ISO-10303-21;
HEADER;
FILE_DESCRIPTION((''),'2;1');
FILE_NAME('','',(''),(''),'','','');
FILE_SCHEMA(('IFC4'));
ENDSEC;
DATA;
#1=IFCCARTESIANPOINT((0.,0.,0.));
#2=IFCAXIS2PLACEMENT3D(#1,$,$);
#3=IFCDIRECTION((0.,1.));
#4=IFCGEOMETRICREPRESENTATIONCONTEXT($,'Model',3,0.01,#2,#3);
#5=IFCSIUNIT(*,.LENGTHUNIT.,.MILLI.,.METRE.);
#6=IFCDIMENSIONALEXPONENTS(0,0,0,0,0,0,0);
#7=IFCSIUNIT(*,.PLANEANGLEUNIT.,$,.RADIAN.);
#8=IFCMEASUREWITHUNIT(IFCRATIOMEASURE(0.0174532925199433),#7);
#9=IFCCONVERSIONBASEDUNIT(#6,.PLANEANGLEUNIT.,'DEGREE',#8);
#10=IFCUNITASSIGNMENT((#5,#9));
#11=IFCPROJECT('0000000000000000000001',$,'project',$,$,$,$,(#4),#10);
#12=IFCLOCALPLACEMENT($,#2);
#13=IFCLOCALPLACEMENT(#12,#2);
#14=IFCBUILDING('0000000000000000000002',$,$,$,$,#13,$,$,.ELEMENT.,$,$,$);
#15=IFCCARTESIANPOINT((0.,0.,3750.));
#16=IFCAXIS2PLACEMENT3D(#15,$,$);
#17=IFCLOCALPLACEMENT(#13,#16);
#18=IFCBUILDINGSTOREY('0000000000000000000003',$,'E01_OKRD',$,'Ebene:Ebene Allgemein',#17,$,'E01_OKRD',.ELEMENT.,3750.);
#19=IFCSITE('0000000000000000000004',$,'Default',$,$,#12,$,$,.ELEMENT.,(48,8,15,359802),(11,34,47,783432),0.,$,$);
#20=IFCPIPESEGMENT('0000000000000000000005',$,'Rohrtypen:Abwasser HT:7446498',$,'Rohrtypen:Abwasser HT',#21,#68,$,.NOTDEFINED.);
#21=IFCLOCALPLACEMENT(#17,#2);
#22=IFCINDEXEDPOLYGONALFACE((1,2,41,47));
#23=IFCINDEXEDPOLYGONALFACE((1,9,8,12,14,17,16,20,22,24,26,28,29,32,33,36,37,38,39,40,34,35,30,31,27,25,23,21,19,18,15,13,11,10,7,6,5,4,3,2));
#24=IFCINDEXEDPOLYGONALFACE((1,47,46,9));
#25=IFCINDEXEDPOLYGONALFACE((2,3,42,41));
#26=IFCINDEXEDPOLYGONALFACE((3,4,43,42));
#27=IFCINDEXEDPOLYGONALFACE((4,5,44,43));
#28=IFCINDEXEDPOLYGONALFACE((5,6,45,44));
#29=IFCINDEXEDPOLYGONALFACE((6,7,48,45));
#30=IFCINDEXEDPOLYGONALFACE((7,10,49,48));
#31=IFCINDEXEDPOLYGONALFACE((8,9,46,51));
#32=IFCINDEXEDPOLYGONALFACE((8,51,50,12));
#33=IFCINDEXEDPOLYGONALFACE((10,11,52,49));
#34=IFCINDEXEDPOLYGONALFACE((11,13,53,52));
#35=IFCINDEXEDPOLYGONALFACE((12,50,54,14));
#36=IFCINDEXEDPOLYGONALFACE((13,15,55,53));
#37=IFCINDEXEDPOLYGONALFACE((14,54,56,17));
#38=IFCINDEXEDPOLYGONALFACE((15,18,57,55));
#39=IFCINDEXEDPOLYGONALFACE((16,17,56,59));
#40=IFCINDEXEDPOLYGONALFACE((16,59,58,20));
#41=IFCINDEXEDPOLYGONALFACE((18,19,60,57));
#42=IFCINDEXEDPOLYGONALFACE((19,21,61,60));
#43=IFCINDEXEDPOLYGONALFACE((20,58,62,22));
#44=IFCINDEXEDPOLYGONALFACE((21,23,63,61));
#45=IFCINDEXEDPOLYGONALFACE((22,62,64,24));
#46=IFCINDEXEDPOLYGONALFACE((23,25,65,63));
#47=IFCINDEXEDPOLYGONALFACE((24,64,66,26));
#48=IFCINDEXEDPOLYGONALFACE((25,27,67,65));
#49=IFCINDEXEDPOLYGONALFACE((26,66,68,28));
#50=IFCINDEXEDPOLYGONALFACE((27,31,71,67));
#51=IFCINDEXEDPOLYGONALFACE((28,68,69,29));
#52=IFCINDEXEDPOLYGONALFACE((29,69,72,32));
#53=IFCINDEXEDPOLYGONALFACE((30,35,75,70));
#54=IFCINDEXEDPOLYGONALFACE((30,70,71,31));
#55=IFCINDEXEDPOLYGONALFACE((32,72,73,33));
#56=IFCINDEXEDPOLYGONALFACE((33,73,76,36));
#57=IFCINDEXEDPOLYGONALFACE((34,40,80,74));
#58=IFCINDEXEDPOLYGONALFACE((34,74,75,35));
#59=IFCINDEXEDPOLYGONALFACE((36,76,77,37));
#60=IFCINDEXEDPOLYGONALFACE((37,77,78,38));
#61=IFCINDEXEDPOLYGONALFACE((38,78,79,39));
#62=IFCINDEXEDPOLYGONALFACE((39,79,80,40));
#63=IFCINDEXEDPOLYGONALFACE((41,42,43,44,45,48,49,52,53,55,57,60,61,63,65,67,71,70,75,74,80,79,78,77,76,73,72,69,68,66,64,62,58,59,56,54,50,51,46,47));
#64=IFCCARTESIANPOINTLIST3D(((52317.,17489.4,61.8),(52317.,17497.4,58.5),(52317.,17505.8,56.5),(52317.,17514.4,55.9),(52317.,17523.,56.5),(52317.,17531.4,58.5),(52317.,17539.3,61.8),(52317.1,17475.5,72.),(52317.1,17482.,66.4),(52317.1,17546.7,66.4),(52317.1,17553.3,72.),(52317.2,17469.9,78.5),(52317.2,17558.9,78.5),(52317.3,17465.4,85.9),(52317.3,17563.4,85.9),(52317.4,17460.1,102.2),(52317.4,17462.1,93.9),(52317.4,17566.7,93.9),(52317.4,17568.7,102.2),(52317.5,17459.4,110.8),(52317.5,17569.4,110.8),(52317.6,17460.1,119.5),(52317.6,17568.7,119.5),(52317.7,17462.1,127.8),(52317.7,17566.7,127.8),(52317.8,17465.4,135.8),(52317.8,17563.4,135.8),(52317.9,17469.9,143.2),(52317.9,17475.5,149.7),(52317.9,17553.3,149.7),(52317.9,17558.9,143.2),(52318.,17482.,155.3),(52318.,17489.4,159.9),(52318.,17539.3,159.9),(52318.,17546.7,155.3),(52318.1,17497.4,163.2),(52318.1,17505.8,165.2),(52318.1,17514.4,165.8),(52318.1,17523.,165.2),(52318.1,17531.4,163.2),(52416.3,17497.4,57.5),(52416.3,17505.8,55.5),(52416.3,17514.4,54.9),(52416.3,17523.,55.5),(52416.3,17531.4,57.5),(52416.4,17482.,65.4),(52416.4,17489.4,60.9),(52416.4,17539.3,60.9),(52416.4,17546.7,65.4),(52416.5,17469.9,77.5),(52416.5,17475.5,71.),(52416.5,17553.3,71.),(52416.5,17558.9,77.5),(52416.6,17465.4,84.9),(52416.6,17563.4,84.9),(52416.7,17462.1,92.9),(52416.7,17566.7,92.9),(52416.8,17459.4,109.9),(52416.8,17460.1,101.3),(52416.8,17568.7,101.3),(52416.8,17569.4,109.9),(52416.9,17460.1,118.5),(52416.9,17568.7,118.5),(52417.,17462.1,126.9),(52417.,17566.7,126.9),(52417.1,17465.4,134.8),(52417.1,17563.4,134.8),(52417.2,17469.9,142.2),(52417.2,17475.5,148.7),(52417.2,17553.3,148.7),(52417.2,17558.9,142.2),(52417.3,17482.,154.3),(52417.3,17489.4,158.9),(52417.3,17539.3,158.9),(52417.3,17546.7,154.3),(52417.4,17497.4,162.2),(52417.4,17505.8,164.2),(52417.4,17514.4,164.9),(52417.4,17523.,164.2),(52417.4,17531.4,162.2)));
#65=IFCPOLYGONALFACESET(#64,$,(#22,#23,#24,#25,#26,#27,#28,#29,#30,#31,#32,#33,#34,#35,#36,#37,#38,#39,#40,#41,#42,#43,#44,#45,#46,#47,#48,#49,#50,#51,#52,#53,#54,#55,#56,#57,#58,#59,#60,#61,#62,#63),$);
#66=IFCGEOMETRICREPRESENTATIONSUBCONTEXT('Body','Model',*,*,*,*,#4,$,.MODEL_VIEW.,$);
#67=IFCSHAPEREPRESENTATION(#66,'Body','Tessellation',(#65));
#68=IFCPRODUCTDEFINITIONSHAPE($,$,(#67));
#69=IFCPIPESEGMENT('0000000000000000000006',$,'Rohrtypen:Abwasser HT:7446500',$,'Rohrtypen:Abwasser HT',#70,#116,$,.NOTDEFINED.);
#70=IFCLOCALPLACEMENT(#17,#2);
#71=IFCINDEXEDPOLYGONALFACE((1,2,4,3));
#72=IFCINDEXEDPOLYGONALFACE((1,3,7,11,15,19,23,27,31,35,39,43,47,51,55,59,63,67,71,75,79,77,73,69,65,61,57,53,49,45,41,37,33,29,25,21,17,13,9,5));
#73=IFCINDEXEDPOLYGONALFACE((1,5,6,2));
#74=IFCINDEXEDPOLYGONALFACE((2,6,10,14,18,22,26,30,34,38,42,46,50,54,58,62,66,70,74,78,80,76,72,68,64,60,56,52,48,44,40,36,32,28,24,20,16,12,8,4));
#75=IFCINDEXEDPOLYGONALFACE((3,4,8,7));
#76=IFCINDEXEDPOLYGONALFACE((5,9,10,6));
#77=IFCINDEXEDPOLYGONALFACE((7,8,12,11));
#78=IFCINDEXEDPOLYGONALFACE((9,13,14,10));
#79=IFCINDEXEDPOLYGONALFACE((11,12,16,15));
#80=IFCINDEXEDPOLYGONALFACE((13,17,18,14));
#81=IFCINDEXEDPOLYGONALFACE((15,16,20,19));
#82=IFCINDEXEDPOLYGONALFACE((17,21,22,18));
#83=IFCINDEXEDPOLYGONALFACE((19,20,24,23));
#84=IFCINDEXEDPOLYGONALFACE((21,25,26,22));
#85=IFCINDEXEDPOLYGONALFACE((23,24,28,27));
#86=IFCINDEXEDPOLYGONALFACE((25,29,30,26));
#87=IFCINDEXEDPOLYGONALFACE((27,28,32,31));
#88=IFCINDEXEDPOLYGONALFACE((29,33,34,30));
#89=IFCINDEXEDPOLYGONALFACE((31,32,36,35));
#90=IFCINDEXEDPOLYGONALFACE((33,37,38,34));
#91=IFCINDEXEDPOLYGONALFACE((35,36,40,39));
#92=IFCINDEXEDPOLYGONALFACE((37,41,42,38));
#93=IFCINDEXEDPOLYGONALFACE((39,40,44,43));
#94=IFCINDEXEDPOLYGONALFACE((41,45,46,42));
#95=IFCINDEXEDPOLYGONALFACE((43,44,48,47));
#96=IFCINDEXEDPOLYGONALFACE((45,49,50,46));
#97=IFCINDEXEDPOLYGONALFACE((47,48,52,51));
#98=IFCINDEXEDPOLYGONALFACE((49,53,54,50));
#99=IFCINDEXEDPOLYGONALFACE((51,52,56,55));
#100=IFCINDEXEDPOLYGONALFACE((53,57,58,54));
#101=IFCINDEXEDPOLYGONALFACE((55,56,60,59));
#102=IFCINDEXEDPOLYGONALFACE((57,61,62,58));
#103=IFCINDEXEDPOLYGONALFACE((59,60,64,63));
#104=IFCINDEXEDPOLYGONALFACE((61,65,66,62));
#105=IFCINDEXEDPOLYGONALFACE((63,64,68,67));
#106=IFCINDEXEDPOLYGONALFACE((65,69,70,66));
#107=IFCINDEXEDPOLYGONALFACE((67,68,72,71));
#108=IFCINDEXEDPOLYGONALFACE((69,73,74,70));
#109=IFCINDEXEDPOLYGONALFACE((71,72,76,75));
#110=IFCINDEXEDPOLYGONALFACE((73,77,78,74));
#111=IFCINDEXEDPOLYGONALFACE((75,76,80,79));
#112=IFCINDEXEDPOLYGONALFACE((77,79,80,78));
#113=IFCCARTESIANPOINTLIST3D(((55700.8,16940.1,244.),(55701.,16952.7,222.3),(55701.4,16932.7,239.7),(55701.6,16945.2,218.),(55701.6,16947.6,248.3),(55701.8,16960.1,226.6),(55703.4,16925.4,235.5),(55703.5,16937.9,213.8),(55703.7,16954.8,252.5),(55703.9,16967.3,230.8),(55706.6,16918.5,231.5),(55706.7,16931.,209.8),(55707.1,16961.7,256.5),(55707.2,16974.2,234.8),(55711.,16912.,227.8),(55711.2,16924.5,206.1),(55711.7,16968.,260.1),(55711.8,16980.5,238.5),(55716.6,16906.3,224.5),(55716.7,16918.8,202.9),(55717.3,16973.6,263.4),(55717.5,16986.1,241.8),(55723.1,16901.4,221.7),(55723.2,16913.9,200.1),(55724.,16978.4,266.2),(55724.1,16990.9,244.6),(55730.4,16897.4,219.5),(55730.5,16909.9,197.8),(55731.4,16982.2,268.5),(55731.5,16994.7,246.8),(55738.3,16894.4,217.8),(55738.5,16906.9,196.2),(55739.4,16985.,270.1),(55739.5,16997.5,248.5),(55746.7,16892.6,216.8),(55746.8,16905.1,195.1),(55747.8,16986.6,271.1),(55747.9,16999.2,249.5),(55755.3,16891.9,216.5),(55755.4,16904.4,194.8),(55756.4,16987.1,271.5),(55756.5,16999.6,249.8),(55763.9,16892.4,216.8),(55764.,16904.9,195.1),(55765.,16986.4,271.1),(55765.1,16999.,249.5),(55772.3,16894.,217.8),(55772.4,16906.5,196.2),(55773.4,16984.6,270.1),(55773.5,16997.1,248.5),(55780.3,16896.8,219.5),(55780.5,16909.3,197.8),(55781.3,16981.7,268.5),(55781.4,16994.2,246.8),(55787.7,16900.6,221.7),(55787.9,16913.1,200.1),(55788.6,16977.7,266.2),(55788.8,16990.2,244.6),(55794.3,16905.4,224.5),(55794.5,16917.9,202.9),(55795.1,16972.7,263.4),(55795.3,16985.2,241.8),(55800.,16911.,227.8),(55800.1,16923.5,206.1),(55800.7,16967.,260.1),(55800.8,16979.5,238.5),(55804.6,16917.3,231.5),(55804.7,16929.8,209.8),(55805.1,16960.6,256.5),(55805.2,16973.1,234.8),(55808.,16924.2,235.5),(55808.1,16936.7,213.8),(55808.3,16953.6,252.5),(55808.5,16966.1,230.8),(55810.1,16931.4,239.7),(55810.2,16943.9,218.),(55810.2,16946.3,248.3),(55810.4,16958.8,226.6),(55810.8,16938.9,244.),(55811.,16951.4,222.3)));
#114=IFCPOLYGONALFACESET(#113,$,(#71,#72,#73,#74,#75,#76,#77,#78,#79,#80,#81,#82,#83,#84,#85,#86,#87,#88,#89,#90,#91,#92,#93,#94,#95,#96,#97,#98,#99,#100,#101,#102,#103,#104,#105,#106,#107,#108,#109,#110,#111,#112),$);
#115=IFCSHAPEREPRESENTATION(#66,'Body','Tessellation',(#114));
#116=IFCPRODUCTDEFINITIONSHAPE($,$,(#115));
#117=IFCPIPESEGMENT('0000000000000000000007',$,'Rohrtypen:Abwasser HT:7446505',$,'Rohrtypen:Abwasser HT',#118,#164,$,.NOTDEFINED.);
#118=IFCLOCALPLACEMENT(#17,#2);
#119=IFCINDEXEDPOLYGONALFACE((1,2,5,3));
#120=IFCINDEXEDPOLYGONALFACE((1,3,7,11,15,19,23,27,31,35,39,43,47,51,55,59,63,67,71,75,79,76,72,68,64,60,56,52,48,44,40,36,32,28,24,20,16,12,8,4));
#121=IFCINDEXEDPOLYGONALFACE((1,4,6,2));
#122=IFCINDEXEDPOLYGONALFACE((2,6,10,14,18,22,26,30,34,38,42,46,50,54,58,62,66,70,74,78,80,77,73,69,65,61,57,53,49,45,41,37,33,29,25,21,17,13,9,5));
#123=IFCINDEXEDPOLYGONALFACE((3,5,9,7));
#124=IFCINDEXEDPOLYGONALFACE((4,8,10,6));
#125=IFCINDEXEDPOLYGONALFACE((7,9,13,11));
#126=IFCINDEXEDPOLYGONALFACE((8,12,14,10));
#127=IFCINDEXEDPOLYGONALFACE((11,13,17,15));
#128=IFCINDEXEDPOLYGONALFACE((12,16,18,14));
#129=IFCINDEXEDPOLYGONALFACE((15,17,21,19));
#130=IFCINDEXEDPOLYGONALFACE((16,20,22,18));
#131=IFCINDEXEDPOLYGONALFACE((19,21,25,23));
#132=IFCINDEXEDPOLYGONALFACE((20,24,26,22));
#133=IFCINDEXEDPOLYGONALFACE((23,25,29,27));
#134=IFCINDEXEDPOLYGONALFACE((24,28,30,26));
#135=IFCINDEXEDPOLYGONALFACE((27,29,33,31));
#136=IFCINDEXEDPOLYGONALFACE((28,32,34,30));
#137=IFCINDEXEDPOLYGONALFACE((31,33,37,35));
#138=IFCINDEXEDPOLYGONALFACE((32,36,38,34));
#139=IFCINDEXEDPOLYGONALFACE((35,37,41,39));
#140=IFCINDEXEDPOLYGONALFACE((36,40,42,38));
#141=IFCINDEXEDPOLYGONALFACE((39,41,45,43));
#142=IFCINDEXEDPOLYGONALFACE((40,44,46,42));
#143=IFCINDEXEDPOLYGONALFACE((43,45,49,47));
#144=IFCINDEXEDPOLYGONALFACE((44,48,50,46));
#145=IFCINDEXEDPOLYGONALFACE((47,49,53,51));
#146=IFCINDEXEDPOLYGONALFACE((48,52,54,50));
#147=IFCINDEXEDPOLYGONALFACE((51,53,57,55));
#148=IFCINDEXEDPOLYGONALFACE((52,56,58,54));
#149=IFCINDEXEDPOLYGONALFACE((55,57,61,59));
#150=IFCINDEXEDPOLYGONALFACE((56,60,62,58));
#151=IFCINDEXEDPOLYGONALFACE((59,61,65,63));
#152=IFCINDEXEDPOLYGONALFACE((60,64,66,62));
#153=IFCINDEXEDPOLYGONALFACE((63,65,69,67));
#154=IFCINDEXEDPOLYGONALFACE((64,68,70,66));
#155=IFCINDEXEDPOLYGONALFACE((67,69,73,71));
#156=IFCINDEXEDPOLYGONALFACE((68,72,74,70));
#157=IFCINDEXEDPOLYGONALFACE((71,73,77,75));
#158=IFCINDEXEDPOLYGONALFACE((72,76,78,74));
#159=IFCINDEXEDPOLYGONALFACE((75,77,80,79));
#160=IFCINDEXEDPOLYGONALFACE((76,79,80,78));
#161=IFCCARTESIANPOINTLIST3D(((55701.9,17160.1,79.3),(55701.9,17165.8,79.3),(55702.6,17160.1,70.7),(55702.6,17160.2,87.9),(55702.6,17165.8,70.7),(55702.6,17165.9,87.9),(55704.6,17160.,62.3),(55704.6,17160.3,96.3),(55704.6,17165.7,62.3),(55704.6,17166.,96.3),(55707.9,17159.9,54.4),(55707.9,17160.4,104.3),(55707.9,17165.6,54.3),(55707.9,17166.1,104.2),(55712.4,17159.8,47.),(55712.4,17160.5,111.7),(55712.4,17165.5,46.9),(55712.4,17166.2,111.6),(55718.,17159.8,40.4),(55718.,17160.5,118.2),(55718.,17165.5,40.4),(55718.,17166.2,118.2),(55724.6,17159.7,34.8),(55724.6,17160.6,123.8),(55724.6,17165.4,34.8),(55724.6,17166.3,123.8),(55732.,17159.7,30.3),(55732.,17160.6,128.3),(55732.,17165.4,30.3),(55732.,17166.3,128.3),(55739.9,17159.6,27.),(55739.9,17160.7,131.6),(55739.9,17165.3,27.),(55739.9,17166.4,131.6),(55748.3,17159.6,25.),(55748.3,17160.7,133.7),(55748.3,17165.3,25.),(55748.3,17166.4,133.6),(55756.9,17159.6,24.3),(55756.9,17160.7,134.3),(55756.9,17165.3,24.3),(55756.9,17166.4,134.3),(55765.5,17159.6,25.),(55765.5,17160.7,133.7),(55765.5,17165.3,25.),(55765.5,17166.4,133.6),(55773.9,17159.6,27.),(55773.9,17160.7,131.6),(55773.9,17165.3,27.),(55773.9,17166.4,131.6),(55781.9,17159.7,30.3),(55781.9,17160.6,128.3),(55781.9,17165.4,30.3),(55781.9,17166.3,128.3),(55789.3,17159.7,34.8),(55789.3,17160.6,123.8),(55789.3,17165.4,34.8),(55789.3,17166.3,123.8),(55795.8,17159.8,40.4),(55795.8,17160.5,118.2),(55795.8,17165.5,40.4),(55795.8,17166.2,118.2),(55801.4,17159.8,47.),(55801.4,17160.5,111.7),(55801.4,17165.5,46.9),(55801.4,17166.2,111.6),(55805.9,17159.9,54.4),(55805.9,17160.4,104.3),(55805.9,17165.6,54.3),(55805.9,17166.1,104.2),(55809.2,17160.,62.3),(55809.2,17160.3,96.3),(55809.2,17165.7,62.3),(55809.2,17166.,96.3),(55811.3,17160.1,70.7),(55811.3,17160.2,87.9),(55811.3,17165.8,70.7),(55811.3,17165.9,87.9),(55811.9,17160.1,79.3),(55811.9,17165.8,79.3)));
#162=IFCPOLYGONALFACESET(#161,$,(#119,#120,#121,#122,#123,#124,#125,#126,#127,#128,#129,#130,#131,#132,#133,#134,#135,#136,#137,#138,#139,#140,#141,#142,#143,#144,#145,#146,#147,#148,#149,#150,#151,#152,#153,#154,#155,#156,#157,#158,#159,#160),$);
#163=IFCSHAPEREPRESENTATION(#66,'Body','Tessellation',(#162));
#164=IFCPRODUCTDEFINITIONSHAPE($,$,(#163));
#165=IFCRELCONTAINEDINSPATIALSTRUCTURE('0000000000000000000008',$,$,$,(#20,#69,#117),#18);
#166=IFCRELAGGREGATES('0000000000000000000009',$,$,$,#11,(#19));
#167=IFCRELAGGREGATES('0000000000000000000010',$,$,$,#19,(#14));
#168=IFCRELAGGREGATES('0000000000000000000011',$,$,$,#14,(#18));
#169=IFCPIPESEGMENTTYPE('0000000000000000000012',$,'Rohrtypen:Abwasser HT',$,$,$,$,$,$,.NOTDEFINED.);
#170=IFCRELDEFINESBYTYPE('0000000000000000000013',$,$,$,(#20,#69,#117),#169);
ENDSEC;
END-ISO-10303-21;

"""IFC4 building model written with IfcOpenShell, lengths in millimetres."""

from ifc_helpers import new_model, entity, si_unit, converted_unit, direction, frame, origin, place, context, subcontext, project, spatial, indexed_curve, outline, extrude, type_object, element, save


model = new_model("IFC4")

# Units and contexts
model_context = context("Model", 3, precision=0.01, world=origin(), true_north=direction((0.0, 1.0)))
body_context = subcontext(model_context, "Body", "Model", "MODEL_VIEW")
ifc_project = project(units=[si_unit("LENGTHUNIT", "METRE", prefix="MILLI"), converted_unit("PLANEANGLEUNIT", "DEGREE", entity("IfcRatioMeasure", 0.0174532925199433), si_unit("PLANEANGLEUNIT", "RADIAN"), dimensions=[0, 0, 0, 0, 0, 0, 0])], contexts=[model_context])

# Site, building, storey
site_placement = place(None, origin())
site = spatial("IfcSite", under=ifc_project, at=site_placement, Name="Default", CompositionType="ELEMENT", RefLatitude=(48, 8, 15, 359802), RefLongitude=(11, 34, 47, 783432), RefElevation=0.0)
building_placement = place(site_placement, origin())
building = spatial("IfcBuilding", under=site, at=building_placement, CompositionType="ELEMENT")
storey_placement = place(building_placement, frame((0.0, 0.0, 3750.0)))
storey = spatial("IfcBuildingStorey", under=building, at=storey_placement, Name="E01_OKRD", ObjectType="Ebene:Ebene Allgemein", LongName="E01_OKRD", CompositionType="ELEMENT", Elevation=3750.0)

# Pipe segments
pipe_segment_type_1 = type_object("IfcPipeSegmentType", Name="Rohrtypen:Abwasser HT", PredefinedType="NOTDEFINED")
pipe_segment_1_placement = place(storey_placement, origin())
element("IfcPipeSegment", 1, at=pipe_segment_1_placement, inside=storey, type_object=pipe_segment_type_1, Name="Rohrtypen:Abwasser HT:7446498", ObjectType="Rohrtypen:Abwasser HT", PredefinedType="NOTDEFINED", context=body_context, shape_type="SweptSolid", body=[
    extrude(outline(indexed_curve([(55.0, 0.0), (54.3, 8.6), (52.3, 17.0), (49.0, 25.0), (44.5, 32.3), (38.9, 38.9), (32.3, 44.5), (25.0, 49.0), (17.0, 52.3), (8.6, 54.3), (0.0, 55.0), (-8.6, 54.3), (-17.0, 52.3), (-25.0, 49.0), (-32.3, 44.5), (-38.9, 38.9), (-44.5, 32.3), (-49.0, 25.0), (-52.3, 17.0), (-54.3, 8.6), (-55.0, 0.0), (-54.3, -8.6), (-52.3, -17.0), (-49.0, -25.0), (-44.5, -32.3), (-38.9, -38.9), (-32.3, -44.5), (-25.0, -49.0), (-17.0, -52.3), (-8.6, -54.3), (0.0, -55.0), (8.6, -54.3), (17.0, -52.3), (25.0, -49.0), (32.3, -44.5), (38.9, -38.9), (44.5, -32.3), (49.0, -25.0), (52.3, -17.0), (54.3, -8.6), (55.0, 0.0)], self_intersect=False)), frame((52416.8, 17514.4, 109.9), z_axis=(-0.99995, 0.0, 0.01), x_axis=(0.0, 1.0, 0.0)), (0.0, 0.0, 1.0), 99.3),
])
pipe_segment_2_placement = place(storey_placement, origin())
element("IfcPipeSegment", 2, at=pipe_segment_2_placement, inside=storey, type_object=pipe_segment_type_1, Name="Rohrtypen:Abwasser HT:7446500", ObjectType="Rohrtypen:Abwasser HT", PredefinedType="NOTDEFINED", context=body_context, shape_type="SweptSolid", body=[
    extrude(outline(indexed_curve([(55.0, 0.0), (54.3, 8.6), (52.3, 17.0), (49.0, 25.0), (44.5, 32.3), (38.9, 38.9), (32.3, 44.5), (25.0, 49.0), (17.0, 52.3), (8.6, 54.3), (0.0, 55.0), (-8.6, 54.3), (-17.0, 52.3), (-25.0, 49.0), (-32.3, 44.5), (-38.9, 38.9), (-44.5, 32.3), (-49.0, 25.0), (-52.3, 17.0), (-54.3, 8.6), (-55.0, 0.0), (-54.3, -8.6), (-52.3, -17.0), (-49.0, -25.0), (-44.5, -32.3), (-38.9, -38.9), (-32.3, -44.5), (-25.0, -49.0), (-17.0, -52.3), (-8.6, -54.3), (0.0, -55.0), (8.6, -54.3), (17.0, -52.3), (25.0, -49.0), (32.3, -44.5), (38.9, -38.9), (44.5, -32.3), (49.0, -25.0), (52.3, -17.0), (54.3, -8.6), (55.0, 0.0)], self_intersect=False)), frame((55755.8, 16939.5, 244.0), z_axis=(0.005834, 0.499991, -0.866011), x_axis=(0.999932, -0.011668, 0.0)), (0.0, 0.0, 1.0), 25.0),
])
pipe_segment_3_placement = place(storey_placement, origin())
element("IfcPipeSegment", 3, at=pipe_segment_3_placement, inside=storey, type_object=pipe_segment_type_1, Name="Rohrtypen:Abwasser HT:7446505", ObjectType="Rohrtypen:Abwasser HT", PredefinedType="NOTDEFINED", context=body_context, shape_type="SweptSolid", body=[
    extrude(outline(indexed_curve([(55.0, 0.0), (54.3, 8.6), (52.3, 17.0), (49.0, 25.0), (44.5, 32.3), (38.9, 38.9), (32.3, 44.5), (25.0, 49.0), (17.0, 52.3), (8.6, 54.3), (0.0, 55.0), (-8.6, 54.3), (-17.0, 52.3), (-25.0, 49.0), (-32.3, 44.5), (-38.9, 38.9), (-44.5, 32.3), (-49.0, 25.0), (-52.3, 17.0), (-54.3, 8.6), (-55.0, 0.0), (-54.3, -8.6), (-52.3, -17.0), (-49.0, -25.0), (-44.5, -32.3), (-38.9, -38.9), (-32.3, -44.5), (-25.0, -49.0), (-17.0, -52.3), (-8.6, -54.3), (0.0, -55.0), (8.6, -54.3), (17.0, -52.3), (25.0, -49.0), (32.3, -44.5), (38.9, -38.9), (44.5, -32.3), (49.0, -25.0), (52.3, -17.0), (54.3, -8.6), (55.0, 0.0)], self_intersect=False)), frame((55756.9, 17160.1, 79.3), z_axis=(0.0, 0.99995, -0.010016), x_axis=(1.0, 0.0, 0.0)), (0.0, 0.0, 1.0), 5.7),
])

save(model, "model.ifc")
